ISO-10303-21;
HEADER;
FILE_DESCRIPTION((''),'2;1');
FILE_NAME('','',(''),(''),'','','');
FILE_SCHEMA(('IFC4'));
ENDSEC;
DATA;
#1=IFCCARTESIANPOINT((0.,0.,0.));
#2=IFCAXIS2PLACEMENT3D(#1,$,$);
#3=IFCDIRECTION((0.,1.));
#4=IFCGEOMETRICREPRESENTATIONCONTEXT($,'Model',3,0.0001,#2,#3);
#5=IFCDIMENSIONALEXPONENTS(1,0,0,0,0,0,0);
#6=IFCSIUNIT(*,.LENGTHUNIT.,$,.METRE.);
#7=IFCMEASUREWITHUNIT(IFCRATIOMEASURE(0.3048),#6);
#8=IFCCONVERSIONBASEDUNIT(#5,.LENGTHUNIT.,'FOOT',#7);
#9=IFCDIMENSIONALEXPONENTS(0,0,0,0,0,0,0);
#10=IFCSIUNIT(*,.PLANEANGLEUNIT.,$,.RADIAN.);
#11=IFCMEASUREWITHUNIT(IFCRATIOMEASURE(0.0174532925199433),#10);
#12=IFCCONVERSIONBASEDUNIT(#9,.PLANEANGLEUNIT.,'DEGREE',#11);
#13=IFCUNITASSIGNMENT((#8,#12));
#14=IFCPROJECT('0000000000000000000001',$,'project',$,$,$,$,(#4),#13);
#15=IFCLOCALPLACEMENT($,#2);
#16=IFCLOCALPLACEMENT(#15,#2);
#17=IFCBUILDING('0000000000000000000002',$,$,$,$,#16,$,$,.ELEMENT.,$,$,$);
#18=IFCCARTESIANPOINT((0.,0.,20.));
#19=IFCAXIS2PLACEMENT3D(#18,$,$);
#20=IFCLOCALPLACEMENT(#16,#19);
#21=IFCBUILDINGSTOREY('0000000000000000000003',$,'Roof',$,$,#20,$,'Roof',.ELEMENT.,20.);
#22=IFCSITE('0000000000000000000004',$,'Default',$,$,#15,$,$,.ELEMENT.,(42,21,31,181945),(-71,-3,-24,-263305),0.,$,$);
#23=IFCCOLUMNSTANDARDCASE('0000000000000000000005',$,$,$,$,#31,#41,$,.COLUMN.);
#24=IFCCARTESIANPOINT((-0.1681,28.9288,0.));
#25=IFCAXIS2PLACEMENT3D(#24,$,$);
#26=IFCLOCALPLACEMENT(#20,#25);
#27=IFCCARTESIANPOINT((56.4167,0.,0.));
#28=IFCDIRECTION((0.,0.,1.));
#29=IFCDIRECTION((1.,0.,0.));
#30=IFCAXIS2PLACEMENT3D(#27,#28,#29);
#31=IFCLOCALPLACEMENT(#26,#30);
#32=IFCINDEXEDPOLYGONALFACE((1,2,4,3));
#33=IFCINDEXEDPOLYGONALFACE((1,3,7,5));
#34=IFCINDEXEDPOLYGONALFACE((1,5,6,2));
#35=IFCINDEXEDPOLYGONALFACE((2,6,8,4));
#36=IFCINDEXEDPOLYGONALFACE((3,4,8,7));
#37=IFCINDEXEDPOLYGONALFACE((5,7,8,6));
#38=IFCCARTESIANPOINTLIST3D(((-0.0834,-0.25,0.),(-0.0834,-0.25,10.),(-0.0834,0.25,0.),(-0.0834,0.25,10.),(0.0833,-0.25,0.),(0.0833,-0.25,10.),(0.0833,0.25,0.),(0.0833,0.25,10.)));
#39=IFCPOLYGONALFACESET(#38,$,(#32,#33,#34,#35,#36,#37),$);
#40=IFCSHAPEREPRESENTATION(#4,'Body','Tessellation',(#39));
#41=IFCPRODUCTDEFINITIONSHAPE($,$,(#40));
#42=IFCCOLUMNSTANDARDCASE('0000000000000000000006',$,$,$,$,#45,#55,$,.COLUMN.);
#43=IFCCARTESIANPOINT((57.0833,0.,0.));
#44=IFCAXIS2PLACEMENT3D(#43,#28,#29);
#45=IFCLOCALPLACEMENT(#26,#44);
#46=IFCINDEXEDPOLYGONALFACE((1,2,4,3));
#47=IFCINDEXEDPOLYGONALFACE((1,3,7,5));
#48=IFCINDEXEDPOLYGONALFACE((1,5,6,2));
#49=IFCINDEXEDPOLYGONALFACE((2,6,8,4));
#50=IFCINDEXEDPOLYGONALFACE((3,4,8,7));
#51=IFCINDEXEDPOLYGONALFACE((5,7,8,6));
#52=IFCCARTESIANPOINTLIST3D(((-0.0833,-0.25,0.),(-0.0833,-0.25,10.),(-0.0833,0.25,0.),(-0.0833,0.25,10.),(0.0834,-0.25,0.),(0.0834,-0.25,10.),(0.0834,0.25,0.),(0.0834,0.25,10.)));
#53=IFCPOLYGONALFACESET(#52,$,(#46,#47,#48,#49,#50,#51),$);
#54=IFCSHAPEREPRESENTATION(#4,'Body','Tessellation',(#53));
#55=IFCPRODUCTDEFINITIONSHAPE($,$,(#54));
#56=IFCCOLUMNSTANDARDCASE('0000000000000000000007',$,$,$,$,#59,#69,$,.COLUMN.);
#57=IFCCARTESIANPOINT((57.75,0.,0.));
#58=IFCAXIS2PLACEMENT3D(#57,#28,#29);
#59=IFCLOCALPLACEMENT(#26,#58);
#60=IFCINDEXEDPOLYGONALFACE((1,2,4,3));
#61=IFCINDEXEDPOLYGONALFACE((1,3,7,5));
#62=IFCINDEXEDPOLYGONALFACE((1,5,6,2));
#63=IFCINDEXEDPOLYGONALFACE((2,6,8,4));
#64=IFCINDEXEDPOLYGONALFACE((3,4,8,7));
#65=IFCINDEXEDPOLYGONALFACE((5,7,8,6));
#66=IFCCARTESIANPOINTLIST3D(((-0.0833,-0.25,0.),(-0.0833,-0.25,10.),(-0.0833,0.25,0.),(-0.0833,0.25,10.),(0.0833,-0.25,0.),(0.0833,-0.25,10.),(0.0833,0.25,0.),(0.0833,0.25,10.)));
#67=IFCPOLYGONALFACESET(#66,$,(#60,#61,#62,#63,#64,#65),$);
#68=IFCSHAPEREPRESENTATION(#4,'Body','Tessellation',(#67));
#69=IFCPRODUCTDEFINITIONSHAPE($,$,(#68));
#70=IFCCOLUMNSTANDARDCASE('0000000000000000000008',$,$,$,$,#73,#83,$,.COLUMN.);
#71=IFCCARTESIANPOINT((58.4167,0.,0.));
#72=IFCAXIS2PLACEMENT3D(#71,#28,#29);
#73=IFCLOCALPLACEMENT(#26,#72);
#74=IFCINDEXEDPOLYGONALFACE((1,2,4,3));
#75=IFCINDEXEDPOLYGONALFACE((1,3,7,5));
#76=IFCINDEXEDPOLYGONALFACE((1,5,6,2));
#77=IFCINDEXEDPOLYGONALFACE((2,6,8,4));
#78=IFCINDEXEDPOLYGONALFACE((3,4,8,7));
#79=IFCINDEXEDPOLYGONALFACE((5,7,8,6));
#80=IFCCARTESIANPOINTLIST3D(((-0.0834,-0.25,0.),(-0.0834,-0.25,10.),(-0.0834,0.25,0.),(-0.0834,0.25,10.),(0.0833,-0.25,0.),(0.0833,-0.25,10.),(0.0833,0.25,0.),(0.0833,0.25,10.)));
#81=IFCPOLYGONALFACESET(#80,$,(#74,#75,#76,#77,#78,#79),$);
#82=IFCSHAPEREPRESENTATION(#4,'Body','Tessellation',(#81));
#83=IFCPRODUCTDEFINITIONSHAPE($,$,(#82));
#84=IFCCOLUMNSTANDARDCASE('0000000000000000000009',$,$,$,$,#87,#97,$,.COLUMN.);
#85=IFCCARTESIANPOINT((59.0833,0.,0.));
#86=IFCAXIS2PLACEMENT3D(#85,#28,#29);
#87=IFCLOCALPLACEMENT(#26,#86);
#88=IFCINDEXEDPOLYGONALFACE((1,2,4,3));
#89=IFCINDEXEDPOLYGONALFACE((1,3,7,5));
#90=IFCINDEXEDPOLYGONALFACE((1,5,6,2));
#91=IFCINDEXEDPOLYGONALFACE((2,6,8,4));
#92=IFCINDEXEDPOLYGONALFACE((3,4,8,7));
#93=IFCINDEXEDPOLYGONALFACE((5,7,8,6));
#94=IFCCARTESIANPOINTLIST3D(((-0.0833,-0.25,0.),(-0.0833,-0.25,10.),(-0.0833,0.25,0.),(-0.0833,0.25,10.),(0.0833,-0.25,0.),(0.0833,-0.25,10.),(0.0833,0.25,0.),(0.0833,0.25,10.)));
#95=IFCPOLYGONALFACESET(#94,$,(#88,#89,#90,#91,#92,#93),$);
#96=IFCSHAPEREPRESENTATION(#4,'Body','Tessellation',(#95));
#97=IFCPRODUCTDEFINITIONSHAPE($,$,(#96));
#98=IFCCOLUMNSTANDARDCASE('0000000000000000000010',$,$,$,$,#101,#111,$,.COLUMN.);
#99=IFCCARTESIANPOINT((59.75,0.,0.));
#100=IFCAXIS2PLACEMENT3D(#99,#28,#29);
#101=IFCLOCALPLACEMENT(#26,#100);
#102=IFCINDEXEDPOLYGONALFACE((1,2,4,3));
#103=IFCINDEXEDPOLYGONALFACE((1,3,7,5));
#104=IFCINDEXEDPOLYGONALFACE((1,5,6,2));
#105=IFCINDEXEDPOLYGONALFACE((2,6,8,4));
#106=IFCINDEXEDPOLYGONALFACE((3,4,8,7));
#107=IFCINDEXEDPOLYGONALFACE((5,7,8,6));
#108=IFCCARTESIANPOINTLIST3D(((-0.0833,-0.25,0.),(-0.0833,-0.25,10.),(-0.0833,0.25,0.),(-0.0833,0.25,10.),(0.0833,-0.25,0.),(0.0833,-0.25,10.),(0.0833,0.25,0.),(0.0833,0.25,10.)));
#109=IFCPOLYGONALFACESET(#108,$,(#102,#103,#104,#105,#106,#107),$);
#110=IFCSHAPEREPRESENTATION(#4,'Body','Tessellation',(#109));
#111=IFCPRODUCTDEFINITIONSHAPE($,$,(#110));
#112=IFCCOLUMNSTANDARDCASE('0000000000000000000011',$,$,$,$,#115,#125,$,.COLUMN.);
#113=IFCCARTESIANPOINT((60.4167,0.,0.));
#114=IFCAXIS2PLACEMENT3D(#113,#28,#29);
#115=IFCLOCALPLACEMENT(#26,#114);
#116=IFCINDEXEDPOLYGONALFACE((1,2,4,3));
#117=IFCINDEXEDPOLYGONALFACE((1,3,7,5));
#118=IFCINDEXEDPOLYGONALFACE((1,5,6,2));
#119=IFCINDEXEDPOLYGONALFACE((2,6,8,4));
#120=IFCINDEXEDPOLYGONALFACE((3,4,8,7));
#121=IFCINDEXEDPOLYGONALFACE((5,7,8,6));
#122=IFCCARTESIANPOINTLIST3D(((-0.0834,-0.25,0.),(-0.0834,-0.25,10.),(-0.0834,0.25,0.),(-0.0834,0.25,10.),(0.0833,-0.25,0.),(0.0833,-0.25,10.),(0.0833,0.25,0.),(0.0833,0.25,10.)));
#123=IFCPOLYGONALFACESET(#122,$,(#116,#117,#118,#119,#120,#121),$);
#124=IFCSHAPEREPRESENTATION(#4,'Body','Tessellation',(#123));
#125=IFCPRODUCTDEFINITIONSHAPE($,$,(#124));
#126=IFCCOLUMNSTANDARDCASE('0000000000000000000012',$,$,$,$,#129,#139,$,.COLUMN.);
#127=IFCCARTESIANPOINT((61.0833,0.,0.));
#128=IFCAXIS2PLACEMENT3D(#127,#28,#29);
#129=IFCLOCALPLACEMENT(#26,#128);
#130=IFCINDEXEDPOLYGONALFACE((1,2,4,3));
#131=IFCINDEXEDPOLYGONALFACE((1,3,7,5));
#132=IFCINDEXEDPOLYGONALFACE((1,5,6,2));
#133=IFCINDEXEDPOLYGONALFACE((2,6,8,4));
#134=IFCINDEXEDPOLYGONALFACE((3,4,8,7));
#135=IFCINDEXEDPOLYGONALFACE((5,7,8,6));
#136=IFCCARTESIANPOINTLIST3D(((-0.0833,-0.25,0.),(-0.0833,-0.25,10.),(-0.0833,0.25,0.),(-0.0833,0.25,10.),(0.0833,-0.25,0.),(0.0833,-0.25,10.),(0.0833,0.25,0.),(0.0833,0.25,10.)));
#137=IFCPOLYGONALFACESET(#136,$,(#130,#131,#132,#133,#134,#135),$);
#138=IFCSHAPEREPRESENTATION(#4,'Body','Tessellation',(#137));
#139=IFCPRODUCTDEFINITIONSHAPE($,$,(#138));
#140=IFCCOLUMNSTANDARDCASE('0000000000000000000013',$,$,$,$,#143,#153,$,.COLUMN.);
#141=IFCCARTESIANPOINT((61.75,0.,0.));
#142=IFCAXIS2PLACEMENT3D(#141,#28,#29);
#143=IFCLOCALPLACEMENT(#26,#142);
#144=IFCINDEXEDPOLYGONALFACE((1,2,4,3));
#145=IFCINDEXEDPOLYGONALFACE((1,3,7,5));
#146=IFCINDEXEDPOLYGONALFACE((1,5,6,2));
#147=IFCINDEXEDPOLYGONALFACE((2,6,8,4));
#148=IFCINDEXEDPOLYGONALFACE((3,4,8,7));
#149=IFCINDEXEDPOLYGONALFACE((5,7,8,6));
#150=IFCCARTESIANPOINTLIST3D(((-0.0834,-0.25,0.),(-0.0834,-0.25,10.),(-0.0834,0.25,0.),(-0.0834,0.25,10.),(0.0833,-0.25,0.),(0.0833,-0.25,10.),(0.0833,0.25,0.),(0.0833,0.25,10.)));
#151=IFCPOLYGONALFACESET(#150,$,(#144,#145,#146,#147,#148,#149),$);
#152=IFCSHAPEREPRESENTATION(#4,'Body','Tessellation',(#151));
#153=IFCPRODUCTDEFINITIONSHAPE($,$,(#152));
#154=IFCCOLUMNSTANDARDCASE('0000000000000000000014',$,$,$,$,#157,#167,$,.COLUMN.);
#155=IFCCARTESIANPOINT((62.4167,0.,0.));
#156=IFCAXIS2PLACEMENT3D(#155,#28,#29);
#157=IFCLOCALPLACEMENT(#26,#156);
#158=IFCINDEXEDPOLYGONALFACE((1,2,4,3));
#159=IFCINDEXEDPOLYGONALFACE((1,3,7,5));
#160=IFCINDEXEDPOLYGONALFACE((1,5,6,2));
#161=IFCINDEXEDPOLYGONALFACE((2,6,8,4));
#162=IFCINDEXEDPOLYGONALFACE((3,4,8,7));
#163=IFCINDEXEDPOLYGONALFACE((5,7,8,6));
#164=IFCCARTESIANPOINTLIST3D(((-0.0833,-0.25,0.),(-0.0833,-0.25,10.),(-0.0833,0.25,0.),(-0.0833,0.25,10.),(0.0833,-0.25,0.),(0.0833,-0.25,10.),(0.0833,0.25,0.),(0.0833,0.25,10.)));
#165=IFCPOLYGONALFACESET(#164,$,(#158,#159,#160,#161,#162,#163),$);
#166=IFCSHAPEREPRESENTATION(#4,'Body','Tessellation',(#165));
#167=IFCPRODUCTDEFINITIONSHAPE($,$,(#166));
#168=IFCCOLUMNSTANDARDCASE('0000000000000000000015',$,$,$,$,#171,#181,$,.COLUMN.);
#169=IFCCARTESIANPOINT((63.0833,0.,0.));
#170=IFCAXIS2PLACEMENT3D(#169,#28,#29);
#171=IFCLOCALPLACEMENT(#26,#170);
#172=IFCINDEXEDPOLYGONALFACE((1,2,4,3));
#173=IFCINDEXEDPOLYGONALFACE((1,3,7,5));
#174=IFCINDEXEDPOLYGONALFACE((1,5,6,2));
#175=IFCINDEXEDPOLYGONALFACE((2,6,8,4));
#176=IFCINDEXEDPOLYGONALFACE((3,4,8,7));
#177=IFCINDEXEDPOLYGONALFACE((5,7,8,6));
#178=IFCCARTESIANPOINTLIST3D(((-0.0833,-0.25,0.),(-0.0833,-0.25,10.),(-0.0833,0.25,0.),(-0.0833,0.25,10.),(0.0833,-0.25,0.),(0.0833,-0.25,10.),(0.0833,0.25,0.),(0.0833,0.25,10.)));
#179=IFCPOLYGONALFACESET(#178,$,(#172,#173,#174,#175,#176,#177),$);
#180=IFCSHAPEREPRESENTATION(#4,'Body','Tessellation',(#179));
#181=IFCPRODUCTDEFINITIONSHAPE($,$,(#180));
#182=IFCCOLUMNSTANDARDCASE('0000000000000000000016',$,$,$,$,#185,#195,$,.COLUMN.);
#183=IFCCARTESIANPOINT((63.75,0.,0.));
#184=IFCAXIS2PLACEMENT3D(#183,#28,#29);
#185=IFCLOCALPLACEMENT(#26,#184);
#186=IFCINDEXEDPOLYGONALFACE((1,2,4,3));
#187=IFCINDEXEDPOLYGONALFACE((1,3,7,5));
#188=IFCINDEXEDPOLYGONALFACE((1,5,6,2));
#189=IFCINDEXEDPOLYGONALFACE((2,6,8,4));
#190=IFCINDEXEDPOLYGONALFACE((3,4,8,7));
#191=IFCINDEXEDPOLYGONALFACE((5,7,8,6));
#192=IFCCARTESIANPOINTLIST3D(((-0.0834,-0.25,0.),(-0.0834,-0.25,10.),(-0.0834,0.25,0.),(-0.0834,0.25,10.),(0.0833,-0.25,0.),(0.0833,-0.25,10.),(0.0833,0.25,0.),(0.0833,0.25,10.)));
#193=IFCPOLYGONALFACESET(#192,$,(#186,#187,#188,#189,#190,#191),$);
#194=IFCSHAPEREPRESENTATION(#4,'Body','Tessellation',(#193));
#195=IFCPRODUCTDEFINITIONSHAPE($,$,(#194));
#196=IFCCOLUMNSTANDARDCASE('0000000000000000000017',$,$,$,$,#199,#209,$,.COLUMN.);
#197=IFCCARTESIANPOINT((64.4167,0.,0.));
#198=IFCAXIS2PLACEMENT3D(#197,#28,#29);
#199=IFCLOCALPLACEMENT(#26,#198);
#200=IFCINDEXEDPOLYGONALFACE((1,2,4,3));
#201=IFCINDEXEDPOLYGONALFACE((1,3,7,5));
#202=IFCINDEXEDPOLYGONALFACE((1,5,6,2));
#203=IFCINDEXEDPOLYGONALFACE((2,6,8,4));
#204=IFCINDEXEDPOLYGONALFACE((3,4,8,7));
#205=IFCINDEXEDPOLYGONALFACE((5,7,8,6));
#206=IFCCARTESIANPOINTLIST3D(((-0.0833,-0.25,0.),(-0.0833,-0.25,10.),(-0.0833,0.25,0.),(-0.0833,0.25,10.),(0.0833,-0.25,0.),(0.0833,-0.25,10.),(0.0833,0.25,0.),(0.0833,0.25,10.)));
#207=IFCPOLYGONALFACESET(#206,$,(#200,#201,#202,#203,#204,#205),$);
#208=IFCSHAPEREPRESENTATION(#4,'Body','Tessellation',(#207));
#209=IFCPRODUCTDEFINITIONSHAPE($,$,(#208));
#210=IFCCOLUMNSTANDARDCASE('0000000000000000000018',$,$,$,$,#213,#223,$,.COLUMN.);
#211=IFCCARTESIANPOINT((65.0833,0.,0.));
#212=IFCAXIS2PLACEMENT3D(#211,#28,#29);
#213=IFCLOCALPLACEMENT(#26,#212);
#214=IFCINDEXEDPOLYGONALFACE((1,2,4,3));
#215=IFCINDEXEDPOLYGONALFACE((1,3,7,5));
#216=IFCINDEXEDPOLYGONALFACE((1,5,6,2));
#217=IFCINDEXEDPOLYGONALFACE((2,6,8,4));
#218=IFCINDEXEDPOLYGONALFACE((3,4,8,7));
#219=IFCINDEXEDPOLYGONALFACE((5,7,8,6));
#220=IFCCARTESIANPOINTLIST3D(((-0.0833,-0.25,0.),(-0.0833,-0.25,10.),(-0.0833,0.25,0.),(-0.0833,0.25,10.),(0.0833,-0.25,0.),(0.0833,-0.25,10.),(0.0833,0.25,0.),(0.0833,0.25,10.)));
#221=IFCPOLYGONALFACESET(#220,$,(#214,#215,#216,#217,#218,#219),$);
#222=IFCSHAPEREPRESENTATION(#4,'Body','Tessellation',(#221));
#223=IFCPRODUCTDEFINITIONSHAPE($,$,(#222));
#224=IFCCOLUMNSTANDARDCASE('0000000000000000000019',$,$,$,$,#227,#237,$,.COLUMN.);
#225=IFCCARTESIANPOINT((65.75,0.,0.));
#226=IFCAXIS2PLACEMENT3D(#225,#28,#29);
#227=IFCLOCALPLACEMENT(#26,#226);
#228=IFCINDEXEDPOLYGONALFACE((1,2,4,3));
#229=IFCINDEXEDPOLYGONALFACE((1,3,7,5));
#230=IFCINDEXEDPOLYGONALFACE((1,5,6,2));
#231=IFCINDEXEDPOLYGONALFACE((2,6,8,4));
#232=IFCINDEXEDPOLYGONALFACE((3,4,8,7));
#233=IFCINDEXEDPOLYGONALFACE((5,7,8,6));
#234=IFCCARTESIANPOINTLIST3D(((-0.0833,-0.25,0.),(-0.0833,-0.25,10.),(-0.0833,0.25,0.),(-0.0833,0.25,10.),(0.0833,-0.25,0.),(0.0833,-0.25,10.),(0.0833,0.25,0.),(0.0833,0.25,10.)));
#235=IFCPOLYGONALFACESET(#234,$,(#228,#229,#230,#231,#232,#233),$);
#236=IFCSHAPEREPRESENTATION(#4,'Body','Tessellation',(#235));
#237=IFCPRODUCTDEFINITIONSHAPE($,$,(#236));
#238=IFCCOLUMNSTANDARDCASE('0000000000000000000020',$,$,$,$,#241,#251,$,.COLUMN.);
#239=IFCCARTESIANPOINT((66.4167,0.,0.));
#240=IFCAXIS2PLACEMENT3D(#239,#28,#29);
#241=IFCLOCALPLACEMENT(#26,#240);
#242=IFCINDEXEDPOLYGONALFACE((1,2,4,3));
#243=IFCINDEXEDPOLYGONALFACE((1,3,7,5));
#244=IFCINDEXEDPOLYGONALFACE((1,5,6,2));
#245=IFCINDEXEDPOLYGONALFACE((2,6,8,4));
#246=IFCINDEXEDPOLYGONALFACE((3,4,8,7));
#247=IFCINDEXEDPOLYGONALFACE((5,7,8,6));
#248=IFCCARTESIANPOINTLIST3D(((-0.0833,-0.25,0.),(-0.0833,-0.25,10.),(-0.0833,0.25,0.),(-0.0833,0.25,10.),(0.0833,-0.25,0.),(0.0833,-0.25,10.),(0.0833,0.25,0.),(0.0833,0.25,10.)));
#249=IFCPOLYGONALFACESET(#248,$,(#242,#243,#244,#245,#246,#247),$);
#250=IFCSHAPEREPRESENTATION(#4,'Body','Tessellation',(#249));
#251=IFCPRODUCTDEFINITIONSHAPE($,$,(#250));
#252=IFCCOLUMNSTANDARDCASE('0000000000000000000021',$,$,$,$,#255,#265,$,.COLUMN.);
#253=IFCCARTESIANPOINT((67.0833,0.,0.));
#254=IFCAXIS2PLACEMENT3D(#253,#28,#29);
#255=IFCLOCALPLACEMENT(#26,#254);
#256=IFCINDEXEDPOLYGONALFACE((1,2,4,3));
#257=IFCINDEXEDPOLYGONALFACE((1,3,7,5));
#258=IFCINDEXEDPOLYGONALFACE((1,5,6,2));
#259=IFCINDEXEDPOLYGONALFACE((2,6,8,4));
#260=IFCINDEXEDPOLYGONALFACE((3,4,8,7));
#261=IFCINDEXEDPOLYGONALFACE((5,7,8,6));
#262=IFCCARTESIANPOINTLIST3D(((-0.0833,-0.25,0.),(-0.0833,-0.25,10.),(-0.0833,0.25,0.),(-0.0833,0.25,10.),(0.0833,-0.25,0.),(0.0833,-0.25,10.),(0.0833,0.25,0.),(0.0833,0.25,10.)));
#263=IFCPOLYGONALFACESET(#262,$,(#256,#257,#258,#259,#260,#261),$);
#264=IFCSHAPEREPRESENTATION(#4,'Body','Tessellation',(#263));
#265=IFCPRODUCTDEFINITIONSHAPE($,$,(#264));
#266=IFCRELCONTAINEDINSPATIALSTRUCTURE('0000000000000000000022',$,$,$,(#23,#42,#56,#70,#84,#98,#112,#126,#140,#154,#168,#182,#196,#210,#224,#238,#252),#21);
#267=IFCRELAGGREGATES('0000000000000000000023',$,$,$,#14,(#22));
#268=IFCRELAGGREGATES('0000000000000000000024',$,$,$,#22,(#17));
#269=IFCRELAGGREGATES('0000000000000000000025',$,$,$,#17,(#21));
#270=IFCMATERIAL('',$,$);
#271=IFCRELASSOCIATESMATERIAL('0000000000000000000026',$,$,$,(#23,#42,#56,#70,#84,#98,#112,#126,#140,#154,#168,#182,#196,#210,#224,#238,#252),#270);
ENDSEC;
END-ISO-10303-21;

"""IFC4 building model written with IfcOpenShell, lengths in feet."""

from ifc_helpers import new_model, entity, si_unit, converted_unit, direction, frame, origin, place, context, project, spatial, rectangle, extrude, material, element, save


model = new_model("IFC4")

# Units and contexts
model_context = context("Model", 3, precision=0.0001, world=origin(), true_north=direction((0.0, 1.0)))
ifc_project = project(units=[converted_unit("LENGTHUNIT", "FOOT", entity("IfcRatioMeasure", 0.3048), si_unit("LENGTHUNIT", "METRE"), dimensions=[1, 0, 0, 0, 0, 0, 0]), converted_unit("PLANEANGLEUNIT", "DEGREE", entity("IfcRatioMeasure", 0.0174532925199433), si_unit("PLANEANGLEUNIT", "RADIAN"), dimensions=[0, 0, 0, 0, 0, 0, 0])], contexts=[model_context])

# Site, building, storey
site_placement = place(None, origin())
site = spatial("IfcSite", under=ifc_project, at=site_placement, Name="Default", CompositionType="ELEMENT", RefLatitude=(42, 21, 31, 181945), RefLongitude=(-71, -3, -24, -263305), RefElevation=0.0)
building_placement = place(site_placement, origin())
building = spatial("IfcBuilding", under=site, at=building_placement, CompositionType="ELEMENT")
storey_placement = place(building_placement, frame((0.0, 0.0, 20.0)))
storey = spatial("IfcBuildingStorey", under=building, at=storey_placement, Name="Roof", LongName="Roof", CompositionType="ELEMENT", Elevation=20.0)

# Columns
ifc_material_1 = material(Name="")
placement = place(storey_placement, frame((-0.1681, 28.9288, 0.0)))
for number, where, z_axis, x_axis in (
    (1, (56.4167, 0.0, 0.0), (0.0, 0.0, 1.0), (1.0, 0.0, 0.0)),
    (2, (57.0833, 0.0, 0.0), (0.0, 0.0, 1.0), (1.0, 0.0, 0.0)),
    (3, (57.75, 0.0, 0.0), (0.0, 0.0, 1.0), (1.0, 0.0, 0.0)),
    (4, (58.4167, 0.0, 0.0), (0.0, 0.0, 1.0), (1.0, 0.0, 0.0)),
    (5, (59.0833, 0.0, 0.0), (0.0, 0.0, 1.0), (1.0, 0.0, 0.0)),
    (6, (59.75, 0.0, 0.0), (0.0, 0.0, 1.0), (1.0, 0.0, 0.0)),
    (7, (60.4167, 0.0, 0.0), (0.0, 0.0, 1.0), (1.0, 0.0, 0.0)),
    (8, (61.0833, 0.0, 0.0), (0.0, 0.0, 1.0), (1.0, 0.0, 0.0)),
    (9, (61.75, 0.0, 0.0), (0.0, 0.0, 1.0), (1.0, 0.0, 0.0)),
    (10, (62.4167, 0.0, 0.0), (0.0, 0.0, 1.0), (1.0, 0.0, 0.0)),
    (11, (63.0833, 0.0, 0.0), (0.0, 0.0, 1.0), (1.0, 0.0, 0.0)),
    (12, (63.75, 0.0, 0.0), (0.0, 0.0, 1.0), (1.0, 0.0, 0.0)),
    (13, (64.4167, 0.0, 0.0), (0.0, 0.0, 1.0), (1.0, 0.0, 0.0)),
    (14, (65.0833, 0.0, 0.0), (0.0, 0.0, 1.0), (1.0, 0.0, 0.0)),
    (15, (65.75, 0.0, 0.0), (0.0, 0.0, 1.0), (1.0, 0.0, 0.0)),
    (16, (66.4167, 0.0, 0.0), (0.0, 0.0, 1.0), (1.0, 0.0, 0.0)),
    (17, (67.0833, 0.0, 0.0), (0.0, 0.0, 1.0), (1.0, 0.0, 0.0)),
):
    element("IfcColumnStandardCase", number, at=place(placement, frame(where, z_axis=z_axis, x_axis=x_axis)), inside=storey, material=ifc_material_1, PredefinedType="COLUMN", context=model_context, shape_type="SweptSolid", body=[
        extrude(rectangle(XDim=0.1667, YDim=0.5), origin(), (0.0, 0.0, 1.0), 10.0),
    ])

save(model, "model.ifc")
